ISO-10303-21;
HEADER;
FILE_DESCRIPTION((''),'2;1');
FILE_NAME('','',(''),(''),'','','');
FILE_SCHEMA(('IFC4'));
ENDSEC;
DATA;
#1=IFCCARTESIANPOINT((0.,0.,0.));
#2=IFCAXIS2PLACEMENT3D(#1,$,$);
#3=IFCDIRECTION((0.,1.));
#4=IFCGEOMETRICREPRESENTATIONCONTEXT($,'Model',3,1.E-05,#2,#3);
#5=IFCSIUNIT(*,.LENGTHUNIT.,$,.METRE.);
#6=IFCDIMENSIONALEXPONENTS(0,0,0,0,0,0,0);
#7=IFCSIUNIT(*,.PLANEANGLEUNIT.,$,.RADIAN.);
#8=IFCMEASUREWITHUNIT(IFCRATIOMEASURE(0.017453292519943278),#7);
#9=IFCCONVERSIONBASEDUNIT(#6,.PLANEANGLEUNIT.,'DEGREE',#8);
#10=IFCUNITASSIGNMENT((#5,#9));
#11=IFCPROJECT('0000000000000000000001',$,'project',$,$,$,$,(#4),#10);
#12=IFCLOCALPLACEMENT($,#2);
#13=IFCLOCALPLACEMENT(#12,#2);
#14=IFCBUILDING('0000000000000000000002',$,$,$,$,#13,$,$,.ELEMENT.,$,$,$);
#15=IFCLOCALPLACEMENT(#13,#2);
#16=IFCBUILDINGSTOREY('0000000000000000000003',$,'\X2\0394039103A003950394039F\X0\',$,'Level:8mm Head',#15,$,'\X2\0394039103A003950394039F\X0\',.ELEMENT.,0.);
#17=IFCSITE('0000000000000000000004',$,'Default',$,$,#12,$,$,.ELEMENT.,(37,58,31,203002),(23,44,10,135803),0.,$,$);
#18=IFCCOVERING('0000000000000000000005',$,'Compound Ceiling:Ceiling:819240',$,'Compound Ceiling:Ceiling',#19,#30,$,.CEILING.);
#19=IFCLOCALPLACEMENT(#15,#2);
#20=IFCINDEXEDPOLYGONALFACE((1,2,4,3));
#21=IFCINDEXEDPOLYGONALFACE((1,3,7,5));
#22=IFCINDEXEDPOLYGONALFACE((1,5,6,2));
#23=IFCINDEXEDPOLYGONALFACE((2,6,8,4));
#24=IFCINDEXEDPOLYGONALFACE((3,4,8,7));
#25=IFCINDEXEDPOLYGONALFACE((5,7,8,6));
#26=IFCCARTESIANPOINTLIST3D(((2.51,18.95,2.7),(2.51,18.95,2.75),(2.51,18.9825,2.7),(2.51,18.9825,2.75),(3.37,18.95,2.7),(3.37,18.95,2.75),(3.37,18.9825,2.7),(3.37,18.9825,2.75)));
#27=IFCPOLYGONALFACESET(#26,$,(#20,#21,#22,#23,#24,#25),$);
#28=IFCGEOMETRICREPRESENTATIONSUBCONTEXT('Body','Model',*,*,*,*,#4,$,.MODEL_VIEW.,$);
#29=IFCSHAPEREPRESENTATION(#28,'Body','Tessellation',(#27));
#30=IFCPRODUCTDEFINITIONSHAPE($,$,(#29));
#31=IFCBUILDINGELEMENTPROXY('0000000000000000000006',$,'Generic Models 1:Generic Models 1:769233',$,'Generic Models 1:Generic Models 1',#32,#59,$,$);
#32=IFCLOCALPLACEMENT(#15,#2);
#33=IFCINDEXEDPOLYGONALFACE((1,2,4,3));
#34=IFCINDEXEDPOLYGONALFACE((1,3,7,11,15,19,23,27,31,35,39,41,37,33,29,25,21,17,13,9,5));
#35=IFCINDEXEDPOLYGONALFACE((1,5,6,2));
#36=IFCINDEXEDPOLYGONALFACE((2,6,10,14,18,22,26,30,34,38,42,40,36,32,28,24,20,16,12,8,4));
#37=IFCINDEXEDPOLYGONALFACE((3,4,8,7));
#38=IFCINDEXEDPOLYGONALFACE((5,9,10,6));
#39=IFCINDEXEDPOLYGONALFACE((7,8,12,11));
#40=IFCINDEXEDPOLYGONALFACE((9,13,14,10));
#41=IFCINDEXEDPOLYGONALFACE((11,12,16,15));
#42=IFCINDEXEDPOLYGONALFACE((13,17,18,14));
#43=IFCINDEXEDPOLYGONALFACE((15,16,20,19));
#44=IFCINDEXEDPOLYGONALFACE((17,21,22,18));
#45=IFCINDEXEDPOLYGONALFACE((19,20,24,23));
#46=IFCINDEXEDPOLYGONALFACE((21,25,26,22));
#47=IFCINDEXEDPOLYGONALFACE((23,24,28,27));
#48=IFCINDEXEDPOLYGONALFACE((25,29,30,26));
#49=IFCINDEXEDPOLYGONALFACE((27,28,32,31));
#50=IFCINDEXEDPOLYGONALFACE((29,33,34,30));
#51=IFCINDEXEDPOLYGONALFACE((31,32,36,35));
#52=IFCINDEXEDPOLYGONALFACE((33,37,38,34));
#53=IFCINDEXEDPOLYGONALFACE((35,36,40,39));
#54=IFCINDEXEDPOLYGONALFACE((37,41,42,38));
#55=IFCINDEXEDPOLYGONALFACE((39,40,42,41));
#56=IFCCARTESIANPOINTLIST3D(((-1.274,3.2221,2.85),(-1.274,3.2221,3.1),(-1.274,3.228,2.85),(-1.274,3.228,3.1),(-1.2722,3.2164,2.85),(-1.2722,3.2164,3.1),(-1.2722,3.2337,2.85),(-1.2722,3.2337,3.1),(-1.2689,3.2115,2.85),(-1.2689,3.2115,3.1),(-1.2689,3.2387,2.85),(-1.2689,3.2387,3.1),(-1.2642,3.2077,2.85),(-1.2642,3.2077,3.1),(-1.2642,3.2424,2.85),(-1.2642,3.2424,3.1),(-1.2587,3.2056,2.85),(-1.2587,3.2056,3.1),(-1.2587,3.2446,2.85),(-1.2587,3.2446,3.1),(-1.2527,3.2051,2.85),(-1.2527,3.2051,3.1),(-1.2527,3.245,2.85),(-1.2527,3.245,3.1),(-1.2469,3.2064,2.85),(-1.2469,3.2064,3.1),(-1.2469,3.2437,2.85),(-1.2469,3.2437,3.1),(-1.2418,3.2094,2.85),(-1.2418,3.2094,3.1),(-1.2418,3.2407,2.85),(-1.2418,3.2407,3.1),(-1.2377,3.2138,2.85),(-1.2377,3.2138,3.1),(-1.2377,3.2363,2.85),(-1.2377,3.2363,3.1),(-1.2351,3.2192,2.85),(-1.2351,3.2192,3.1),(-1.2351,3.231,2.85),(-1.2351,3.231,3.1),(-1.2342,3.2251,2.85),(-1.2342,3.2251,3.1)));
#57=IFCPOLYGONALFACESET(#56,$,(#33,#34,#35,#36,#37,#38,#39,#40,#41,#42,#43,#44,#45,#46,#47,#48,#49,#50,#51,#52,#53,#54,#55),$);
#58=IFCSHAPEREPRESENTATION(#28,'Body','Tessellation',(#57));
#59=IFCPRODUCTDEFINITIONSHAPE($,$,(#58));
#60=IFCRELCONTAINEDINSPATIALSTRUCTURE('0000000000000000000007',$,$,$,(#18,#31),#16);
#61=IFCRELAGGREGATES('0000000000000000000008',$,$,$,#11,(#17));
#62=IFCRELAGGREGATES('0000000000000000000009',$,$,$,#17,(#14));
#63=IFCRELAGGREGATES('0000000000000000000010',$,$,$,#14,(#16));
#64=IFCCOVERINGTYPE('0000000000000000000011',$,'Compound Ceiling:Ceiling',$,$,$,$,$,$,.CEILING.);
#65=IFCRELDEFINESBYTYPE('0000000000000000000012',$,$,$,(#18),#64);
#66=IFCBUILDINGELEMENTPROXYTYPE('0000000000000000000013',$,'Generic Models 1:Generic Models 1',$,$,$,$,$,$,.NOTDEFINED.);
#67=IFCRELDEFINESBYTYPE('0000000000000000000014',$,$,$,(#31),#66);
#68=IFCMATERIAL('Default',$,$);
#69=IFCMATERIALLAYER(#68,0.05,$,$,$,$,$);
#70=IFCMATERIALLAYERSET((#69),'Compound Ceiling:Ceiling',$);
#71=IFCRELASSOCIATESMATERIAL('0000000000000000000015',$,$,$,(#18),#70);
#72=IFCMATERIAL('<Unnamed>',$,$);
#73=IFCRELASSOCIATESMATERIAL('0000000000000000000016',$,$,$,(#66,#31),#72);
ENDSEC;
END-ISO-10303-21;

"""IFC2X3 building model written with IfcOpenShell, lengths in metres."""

from ifc_helpers import new_model, entity, si_unit, converted_unit, direction, frame, frame_2d, origin, origin_2d_with_axis, place, context, subcontext, project, spatial, rectangle, circle, extrude, source, transform, mapped, material, layer, layer_set, layer_usage, type_object, type_shapes, element, save


model = new_model("IFC2X3")

# Units and contexts
model_context = context("Model", 3, precision=1e-05, world=origin(), true_north=direction((0.0, 1.0)))
body_context = subcontext(model_context, "Body", "Model", "MODEL_VIEW")
ifc_project = project(units=[si_unit("LENGTHUNIT", "METRE"), converted_unit("PLANEANGLEUNIT", "DEGREE", entity("IfcRatioMeasure", 0.017453292519943278), si_unit("PLANEANGLEUNIT", "RADIAN"), dimensions=[0, 0, 0, 0, 0, 0, 0])], contexts=[model_context])

# Site, building, storey
site_placement = place(None, origin())
site = spatial("IfcSite", under=ifc_project, at=site_placement, Name="Default", CompositionType="ELEMENT", RefLatitude=(37, 58, 31, 203002), RefLongitude=(23, 44, 10, 135803), RefElevation=0.0)
building_placement = place(site_placement, origin())
building = spatial("IfcBuilding", under=site, at=building_placement, CompositionType="ELEMENT")
storey_placement = place(building_placement, origin())
storey = spatial("IfcBuildingStorey", under=building, at=storey_placement, Name="ΔΑΠΕΔΟ", ObjectType="Level:8mm Head", LongName="ΔΑΠΕΔΟ", CompositionType="ELEMENT", Elevation=0.0)

# Shared definitions
ifc_material_1 = material(Name="Default")

# Covering
ifc_layer_1 = layer(ifc_material_1, 0.05)
ifc_layer_set_1 = layer_set([ifc_layer_1], Name="Compound Ceiling:Ceiling")
ifc_layer_usage_1 = layer_usage(ifc_layer_set_1, "AXIS3", "POSITIVE", 0.0)
covering_type = type_object("IfcCoveringType", Name="Compound Ceiling:Ceiling", PredefinedType="CEILING")
covering_1_placement = place(storey_placement, origin())
element("IfcCovering", 1, at=covering_1_placement, inside=storey, type_object=covering_type, material=ifc_layer_usage_1, Name="Compound Ceiling:Ceiling:819240", ObjectType="Compound Ceiling:Ceiling", PredefinedType="CEILING", context=body_context, shape_type="SweptSolid", body=[
    extrude(rectangle(XDim=0.0325, YDim=0.86, at=frame_2d((0.0, 0.0), x_axis=(1.0, 0.0))), frame((2.94, 18.9663, 2.7), z_axis=(0.0, 0.0, 1.0), x_axis=(0.0, 1.0, 0.0)), (0.0, 0.0, 1.0), 0.05),
])

# Building element proxy
ifc_material_2 = material(Name="<Unnamed>")
building_element_proxy_type = type_object("IfcBuildingElementProxyType", Name="Generic Models 1:Generic Models 1", PredefinedType="NOTDEFINED", material=ifc_material_2)
shared_shape = source(origin(), body_context, "Body", "SweptSolid", [
    extrude(circle(Radius=0.02, at=origin_2d_with_axis()), frame((-1.2542, 3.2251, 2.85)), (0.0, 0.0, 1.0), 0.25),
])
type_shapes(building_element_proxy_type, [shared_shape])
proxy_placement = place(storey_placement, origin())
element("IfcBuildingElementProxy", 2, at=proxy_placement, inside=storey, type_object=building_element_proxy_type, material=ifc_material_2, Name="Generic Models 1:Generic Models 1:769233", ObjectType="Generic Models 1:Generic Models 1", context=body_context, shape_type="MappedRepresentation", body=[
    mapped(shared_shape, transform((0.0, 0.0, 0.0), scale=1.0)),
])

save(model, "model.ifc")
